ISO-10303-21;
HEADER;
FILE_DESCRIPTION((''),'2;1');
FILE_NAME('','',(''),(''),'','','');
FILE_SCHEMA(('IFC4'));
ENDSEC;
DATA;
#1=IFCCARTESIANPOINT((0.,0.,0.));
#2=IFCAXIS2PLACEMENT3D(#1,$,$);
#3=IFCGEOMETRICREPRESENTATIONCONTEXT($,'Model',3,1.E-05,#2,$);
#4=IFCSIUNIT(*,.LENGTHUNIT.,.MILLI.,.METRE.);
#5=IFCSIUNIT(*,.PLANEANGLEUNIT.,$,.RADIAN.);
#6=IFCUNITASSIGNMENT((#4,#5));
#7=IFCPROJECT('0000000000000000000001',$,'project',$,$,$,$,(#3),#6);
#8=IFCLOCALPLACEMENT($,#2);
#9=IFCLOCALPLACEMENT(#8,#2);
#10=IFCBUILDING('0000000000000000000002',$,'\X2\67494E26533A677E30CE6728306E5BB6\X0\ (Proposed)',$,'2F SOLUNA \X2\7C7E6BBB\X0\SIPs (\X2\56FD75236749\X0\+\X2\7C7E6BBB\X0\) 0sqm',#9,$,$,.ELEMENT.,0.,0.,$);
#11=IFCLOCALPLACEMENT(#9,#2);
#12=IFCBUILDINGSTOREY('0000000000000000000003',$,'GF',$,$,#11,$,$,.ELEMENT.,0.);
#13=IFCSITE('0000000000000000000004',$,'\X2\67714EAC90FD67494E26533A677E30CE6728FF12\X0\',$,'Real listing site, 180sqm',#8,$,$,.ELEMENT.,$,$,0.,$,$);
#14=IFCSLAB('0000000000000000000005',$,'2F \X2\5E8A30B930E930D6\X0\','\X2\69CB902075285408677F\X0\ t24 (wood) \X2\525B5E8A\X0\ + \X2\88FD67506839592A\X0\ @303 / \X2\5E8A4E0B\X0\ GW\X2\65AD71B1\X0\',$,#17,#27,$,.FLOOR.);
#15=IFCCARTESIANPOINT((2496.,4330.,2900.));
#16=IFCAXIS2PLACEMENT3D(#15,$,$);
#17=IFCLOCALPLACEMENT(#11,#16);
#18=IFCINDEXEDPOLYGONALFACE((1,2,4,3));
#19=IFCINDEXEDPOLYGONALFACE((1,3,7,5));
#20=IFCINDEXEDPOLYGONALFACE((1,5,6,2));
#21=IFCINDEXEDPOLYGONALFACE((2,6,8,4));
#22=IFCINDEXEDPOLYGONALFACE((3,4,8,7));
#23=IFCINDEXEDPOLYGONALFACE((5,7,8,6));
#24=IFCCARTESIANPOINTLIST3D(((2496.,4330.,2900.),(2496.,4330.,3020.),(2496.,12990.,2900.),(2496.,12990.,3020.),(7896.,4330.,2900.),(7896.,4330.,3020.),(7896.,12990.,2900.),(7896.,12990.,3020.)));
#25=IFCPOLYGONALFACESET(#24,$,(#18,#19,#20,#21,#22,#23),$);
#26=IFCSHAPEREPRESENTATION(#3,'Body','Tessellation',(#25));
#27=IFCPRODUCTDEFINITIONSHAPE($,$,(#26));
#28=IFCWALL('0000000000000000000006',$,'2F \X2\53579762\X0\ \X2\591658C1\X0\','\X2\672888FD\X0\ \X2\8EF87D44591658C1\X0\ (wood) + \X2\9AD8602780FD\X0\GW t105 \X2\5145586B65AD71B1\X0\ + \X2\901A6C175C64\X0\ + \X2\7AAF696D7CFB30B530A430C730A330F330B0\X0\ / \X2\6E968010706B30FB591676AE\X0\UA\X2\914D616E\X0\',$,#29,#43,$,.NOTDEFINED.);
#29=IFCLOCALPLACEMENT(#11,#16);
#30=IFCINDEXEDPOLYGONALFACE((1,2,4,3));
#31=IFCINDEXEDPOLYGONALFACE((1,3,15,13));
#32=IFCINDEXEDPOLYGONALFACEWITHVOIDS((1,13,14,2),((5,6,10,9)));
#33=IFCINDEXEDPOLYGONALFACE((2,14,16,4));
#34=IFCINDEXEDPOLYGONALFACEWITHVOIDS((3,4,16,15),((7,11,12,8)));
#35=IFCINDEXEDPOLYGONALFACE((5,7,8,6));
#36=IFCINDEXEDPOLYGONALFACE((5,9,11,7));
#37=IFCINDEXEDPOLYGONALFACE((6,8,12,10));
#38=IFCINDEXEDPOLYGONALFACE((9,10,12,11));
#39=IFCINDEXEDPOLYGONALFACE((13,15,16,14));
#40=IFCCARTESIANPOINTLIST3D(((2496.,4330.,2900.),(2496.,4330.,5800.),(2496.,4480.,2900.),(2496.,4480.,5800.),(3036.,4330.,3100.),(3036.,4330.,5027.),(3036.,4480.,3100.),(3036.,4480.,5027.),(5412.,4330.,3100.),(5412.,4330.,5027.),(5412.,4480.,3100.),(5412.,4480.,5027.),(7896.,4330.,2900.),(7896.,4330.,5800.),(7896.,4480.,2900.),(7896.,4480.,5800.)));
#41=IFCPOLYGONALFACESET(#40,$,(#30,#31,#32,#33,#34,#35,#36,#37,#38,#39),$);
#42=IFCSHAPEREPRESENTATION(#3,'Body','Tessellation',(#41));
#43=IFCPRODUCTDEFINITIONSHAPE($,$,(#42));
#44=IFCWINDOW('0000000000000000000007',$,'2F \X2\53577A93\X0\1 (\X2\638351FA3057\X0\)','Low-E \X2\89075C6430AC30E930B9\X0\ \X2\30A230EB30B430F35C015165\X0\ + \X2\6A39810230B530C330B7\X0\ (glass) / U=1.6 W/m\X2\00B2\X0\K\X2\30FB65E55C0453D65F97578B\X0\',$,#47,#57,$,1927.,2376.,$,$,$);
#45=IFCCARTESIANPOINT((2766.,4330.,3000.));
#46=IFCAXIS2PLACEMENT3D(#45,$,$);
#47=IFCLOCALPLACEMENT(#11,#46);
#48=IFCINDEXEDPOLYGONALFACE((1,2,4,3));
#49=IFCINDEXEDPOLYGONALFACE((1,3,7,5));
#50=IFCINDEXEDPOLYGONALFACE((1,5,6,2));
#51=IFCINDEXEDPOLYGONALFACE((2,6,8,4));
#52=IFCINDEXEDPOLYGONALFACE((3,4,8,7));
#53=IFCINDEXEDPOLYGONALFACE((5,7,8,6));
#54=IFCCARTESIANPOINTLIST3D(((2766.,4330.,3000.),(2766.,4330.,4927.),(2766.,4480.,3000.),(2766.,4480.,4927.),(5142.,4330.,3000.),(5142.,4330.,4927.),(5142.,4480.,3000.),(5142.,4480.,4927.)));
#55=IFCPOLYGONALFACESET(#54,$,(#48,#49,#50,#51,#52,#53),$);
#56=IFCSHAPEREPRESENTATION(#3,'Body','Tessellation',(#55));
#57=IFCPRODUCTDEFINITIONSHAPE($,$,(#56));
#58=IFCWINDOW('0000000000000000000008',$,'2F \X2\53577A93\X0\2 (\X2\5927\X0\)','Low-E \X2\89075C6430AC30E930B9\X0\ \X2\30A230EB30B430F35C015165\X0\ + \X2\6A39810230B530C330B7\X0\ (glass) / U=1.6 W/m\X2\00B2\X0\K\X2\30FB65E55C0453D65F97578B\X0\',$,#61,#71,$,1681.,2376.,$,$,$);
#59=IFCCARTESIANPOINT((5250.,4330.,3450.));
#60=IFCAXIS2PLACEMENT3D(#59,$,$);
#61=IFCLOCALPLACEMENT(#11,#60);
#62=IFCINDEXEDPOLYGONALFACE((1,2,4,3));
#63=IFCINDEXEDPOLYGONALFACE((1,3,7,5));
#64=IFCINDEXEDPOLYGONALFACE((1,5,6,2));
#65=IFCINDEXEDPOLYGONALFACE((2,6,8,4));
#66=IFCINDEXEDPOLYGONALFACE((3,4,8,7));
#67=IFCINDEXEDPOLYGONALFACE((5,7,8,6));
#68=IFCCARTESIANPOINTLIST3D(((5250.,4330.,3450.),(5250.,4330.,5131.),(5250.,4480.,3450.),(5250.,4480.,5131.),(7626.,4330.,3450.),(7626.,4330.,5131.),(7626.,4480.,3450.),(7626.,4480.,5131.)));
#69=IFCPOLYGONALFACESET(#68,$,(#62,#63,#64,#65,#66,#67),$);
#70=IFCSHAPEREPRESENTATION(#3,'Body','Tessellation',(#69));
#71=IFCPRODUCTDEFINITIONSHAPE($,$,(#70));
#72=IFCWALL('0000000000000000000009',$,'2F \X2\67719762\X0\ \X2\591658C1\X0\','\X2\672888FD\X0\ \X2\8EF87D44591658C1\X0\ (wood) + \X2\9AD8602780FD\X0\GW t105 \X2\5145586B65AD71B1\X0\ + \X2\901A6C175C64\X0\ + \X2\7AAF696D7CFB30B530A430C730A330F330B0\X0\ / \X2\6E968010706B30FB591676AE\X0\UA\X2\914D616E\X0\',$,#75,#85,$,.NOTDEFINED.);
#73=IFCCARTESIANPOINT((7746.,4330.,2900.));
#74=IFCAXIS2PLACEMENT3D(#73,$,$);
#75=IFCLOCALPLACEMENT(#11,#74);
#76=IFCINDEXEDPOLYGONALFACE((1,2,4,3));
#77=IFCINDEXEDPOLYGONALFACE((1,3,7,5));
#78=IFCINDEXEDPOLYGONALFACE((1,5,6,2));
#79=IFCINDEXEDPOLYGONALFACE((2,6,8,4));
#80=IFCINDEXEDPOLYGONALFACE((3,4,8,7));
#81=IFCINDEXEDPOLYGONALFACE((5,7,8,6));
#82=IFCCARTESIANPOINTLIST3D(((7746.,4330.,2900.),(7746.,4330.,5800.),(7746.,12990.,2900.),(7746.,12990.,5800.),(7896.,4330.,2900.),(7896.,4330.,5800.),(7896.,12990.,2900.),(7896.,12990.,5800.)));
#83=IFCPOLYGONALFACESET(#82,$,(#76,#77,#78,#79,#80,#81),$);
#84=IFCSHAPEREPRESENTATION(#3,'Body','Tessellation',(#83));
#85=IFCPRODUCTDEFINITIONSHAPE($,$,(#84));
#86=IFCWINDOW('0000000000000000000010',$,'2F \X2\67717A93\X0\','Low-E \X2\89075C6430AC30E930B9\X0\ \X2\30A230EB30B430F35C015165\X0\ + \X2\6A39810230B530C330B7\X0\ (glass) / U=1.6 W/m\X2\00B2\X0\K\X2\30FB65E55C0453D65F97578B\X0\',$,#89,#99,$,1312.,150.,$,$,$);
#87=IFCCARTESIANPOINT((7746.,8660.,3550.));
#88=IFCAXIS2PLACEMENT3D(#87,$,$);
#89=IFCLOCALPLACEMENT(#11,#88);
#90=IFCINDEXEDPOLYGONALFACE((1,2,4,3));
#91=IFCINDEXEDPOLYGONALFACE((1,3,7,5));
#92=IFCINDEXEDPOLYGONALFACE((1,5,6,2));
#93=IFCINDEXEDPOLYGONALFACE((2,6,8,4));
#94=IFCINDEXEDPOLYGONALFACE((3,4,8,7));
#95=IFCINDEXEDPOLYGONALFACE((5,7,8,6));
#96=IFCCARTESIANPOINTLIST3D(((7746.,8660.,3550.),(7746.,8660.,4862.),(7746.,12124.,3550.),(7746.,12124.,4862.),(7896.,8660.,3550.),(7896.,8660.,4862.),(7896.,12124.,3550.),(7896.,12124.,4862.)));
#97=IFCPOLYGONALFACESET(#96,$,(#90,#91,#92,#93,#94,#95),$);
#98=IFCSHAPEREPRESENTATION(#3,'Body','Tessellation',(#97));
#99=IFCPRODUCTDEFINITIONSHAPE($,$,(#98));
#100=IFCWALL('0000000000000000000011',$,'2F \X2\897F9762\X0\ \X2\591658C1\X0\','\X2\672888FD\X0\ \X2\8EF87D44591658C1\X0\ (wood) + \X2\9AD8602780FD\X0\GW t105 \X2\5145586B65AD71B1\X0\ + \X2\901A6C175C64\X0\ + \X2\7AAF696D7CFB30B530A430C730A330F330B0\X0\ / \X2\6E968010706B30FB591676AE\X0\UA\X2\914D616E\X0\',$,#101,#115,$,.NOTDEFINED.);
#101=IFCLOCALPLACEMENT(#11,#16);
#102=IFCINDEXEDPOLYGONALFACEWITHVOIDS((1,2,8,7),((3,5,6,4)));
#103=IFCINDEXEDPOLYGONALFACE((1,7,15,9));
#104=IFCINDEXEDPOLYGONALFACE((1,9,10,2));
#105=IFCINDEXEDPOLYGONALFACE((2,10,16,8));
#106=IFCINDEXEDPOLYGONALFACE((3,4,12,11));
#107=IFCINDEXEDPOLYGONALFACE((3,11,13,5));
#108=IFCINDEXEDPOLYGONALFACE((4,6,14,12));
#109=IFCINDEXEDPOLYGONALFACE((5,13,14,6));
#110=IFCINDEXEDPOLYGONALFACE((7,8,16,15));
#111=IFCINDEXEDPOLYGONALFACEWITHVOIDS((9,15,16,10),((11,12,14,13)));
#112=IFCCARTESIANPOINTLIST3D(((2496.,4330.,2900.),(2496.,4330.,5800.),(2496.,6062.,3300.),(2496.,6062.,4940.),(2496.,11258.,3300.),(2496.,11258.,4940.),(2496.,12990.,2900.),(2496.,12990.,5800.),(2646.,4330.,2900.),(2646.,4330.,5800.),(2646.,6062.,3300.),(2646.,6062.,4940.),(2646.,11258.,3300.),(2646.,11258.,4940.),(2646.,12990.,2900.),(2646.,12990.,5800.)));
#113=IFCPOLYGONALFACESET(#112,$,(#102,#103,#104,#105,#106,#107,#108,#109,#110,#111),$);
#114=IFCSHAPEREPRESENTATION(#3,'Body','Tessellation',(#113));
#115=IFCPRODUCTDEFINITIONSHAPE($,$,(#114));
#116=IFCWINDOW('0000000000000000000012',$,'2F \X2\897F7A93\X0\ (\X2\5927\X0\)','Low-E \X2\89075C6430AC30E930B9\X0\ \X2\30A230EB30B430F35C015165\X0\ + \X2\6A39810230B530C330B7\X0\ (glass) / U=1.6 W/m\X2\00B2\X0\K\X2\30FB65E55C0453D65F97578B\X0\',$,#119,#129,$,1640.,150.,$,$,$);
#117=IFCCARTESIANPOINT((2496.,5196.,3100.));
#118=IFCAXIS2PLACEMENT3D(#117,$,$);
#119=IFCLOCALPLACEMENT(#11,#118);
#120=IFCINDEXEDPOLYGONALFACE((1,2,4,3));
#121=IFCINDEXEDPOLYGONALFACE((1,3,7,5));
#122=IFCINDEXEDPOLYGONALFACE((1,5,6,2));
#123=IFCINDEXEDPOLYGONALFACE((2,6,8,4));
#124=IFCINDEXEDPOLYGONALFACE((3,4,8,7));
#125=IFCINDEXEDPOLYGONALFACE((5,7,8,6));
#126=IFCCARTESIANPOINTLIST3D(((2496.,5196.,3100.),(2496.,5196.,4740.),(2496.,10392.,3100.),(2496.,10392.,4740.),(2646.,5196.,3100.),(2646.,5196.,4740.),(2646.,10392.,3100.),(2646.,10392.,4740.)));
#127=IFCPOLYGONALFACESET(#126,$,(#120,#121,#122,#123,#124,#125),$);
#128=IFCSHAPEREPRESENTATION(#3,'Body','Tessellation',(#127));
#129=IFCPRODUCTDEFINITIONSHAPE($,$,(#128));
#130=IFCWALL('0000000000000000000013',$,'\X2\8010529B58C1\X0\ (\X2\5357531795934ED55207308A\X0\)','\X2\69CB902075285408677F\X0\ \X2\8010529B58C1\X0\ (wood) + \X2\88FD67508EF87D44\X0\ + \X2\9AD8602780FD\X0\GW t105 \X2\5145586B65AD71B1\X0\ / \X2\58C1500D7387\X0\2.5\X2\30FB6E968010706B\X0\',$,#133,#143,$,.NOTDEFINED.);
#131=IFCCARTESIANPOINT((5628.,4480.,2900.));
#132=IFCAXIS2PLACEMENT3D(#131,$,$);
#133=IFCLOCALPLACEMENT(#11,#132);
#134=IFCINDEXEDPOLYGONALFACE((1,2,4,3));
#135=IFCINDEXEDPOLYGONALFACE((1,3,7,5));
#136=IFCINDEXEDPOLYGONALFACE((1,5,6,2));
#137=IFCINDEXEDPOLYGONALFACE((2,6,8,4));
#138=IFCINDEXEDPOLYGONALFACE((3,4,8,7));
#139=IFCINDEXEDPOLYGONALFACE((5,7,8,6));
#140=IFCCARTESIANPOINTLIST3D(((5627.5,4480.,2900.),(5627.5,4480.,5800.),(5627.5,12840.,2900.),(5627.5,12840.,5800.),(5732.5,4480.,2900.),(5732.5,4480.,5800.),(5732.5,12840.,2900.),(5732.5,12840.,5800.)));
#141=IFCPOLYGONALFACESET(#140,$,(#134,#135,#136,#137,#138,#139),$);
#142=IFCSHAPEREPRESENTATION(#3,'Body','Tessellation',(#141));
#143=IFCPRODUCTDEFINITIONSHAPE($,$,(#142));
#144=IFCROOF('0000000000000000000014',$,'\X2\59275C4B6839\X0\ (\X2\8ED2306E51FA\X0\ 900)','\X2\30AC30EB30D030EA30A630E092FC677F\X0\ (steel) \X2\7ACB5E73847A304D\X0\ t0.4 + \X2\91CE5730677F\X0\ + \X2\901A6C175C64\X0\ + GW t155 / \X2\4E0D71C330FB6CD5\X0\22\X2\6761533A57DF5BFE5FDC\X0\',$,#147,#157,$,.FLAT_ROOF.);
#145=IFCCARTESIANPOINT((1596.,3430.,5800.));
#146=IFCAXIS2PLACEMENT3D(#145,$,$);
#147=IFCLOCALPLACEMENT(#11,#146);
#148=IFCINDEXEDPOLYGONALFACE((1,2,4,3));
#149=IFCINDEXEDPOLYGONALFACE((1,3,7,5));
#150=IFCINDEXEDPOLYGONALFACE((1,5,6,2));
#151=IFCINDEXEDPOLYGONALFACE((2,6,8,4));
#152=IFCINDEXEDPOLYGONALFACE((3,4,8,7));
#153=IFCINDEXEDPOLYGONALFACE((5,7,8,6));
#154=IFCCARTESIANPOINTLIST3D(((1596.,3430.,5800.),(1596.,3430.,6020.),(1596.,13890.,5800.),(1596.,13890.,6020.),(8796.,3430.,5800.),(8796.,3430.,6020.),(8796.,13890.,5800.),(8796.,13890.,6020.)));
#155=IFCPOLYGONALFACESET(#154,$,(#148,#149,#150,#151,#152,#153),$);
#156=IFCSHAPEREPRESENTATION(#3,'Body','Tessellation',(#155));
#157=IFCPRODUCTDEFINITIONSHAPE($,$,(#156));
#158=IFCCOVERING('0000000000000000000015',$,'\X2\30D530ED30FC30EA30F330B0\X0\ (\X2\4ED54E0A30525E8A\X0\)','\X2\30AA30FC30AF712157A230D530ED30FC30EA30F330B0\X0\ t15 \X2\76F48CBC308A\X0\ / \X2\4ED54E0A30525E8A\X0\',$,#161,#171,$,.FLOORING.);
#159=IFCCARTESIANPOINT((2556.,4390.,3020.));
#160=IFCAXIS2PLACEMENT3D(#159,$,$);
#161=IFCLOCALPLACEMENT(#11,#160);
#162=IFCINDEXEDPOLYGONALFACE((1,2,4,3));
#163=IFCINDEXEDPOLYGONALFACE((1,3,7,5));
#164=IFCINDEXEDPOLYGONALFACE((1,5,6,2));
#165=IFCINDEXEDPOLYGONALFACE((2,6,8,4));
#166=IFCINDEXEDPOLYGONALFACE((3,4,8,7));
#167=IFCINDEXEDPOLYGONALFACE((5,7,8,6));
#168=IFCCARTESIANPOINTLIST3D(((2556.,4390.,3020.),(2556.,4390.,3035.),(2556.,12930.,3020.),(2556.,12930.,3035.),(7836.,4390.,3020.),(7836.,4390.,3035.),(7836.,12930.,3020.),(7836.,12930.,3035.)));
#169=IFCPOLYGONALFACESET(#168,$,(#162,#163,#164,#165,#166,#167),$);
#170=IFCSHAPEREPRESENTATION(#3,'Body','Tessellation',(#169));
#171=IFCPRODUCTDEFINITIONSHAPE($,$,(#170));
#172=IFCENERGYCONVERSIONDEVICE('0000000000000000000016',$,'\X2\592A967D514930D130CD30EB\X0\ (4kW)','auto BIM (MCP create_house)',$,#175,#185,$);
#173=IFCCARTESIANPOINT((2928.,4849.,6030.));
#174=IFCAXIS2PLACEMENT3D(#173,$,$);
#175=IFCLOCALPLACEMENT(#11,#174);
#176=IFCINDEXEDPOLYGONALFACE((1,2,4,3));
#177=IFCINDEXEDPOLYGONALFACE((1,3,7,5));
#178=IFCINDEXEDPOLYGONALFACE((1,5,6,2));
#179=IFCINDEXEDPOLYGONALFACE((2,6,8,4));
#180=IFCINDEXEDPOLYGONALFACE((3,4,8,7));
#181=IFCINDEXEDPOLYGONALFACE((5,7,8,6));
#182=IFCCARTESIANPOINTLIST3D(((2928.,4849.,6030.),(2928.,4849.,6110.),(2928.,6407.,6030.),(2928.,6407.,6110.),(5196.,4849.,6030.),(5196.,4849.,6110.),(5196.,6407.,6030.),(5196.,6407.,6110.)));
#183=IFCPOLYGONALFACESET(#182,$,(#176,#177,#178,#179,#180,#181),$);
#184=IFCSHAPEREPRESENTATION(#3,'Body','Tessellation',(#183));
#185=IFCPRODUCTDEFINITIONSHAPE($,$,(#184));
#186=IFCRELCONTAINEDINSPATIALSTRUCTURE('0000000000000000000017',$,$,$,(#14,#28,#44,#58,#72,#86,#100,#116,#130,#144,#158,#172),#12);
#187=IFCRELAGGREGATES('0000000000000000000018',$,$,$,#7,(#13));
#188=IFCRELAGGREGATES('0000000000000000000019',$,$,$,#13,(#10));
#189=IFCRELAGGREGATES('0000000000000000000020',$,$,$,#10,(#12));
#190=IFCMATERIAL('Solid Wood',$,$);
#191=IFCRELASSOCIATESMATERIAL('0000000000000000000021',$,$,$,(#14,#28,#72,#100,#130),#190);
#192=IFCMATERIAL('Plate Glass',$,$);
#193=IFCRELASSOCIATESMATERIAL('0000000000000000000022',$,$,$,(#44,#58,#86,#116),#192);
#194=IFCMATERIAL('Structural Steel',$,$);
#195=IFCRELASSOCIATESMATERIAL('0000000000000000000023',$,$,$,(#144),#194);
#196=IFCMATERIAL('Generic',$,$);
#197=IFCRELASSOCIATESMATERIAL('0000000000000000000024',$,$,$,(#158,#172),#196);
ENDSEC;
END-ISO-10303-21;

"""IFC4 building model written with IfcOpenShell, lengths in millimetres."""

from ifc_helpers import new_model, si_unit, frame, frame_2d, origin, place, context, project, spatial, rectangle, extrude, material, element, fill, save


model = new_model("IFC4")

# Units and contexts
model_context = context("Model", 3, precision=1e-05, world=origin())
ifc_project = project(units=[si_unit("LENGTHUNIT", "METRE", prefix="MILLI"), si_unit("PLANEANGLEUNIT", "RADIAN")], contexts=[model_context])

# Site, building, storey
site_placement = place(None, origin())
site = spatial("IfcSite", under=ifc_project, at=site_placement, Name="東京都杉並区松ノ木２", ObjectType="Real listing site, 180sqm", CompositionType="ELEMENT", RefElevation=0.0)
building_placement = place(site_placement, origin())
building = spatial("IfcBuilding", under=site, at=building_placement, Name="杉並区松ノ木の家 (Proposed)", ObjectType="2F SOLUNA 籾殻SIPs (国産杉+籾殻) 0sqm", CompositionType="ELEMENT", ElevationOfRefHeight=0.0, ElevationOfTerrain=0.0)
storey_placement = place(building_placement, origin())
storey = spatial("IfcBuildingStorey", under=building, at=storey_placement, Name="GF", CompositionType="ELEMENT", Elevation=0.0)

# Slab
ifc_material_1 = material(Name="Solid Wood")
slab_placement = place(storey_placement, frame((2496.0, 4330.0, 2900.0)))
element("IfcSlab", 1, at=slab_placement, inside=storey, material=ifc_material_1, Name="2F 床スラブ", Description="構造用合板 t24 (wood) 剛床 + 製材根太 @303 / 床下 GW断熱", PredefinedType="FLOOR", context=model_context, shape_type="SweptSolid", body=[
    extrude(rectangle(XDim=5400.0, YDim=8660.0, at=frame_2d((2700.0, 4330.0))), frame((2496.0, 4330.0, 2900.0)), (0.0, 0.0, 1.0), 120.0),
])

# Wall, openings, windows
wall_1_placement = place(storey_placement, frame((2496.0, 4330.0, 2900.0)))
wall_1 = element("IfcWall", 2, at=wall_1_placement, inside=storey, material=ifc_material_1, Name="2F 南面 外壁", Description="木製 軸組外壁 (wood) + 高性能GW t105 充填断熱 + 通気層 + 窯業系サイディング / 準耐火・外皮UA配慮", PredefinedType="NOTDEFINED", context=model_context, shape_type="SweptSolid", body=[
    extrude(rectangle(XDim=5400.0, YDim=150.0, at=frame_2d((2700.0, 75.0))), frame((2496.0, 4330.0, 2900.0)), (0.0, 0.0, 1.0), 2900.0),
])
opening_1_placement = place(storey_placement, frame((2766.0, 4330.0, 3000.0)))
opening_1 = element("IfcOpeningElement", 3, at=opening_1_placement, cuts=wall_1, PredefinedType="NOTDEFINED", context=model_context, shape_type="SweptSolid", body=[
    extrude(rectangle(XDim=2376.0, YDim=150.0, at=frame_2d((1188.0, 75.0))), frame((2766.0, 4330.0, 3000.0)), (0.0, 0.0, 1.0), 1927.0),
])
opening_2_placement = place(storey_placement, frame((5250.0, 4330.0, 3450.0)))
opening_2 = element("IfcOpeningElement", 4, at=opening_2_placement, cuts=wall_1, PredefinedType="NOTDEFINED", context=model_context, shape_type="SweptSolid", body=[
    extrude(rectangle(XDim=2376.0, YDim=150.0, at=frame_2d((1188.0, 75.0))), frame((5250.0, 4330.0, 3450.0)), (0.0, 0.0, 1.0), 1681.0),
])
ifc_material_2 = material(Name="Plate Glass")
window_1_placement = place(storey_placement, frame((2766.0, 4330.0, 3000.0)))
window_1 = element("IfcWindow", 5, at=window_1_placement, inside=storey, material=ifc_material_2, Name="2F 南窓1 (掃出し)", Description="Low-E 複層ガラス アルゴン封入 + 樹脂サッシ (glass) / U=1.6 W/m²K・日射取得型", OverallHeight=1927.0, OverallWidth=2376.0, context=model_context, shape_type="SweptSolid", body=[
    extrude(rectangle(XDim=2376.0, YDim=150.0, at=frame_2d((1188.0, 75.0))), frame((2766.0, 4330.0, 3000.0)), (0.0, 0.0, 1.0), 1927.0),
])
fill(opening_1, window_1)
window_2_placement = place(storey_placement, frame((5250.0, 4330.0, 3450.0)))
window_2 = element("IfcWindow", 6, at=window_2_placement, inside=storey, material=ifc_material_2, Name="2F 南窓2 (大)", Description="Low-E 複層ガラス アルゴン封入 + 樹脂サッシ (glass) / U=1.6 W/m²K・日射取得型", OverallHeight=1681.0, OverallWidth=2376.0, context=model_context, shape_type="SweptSolid", body=[
    extrude(rectangle(XDim=2376.0, YDim=150.0, at=frame_2d((1188.0, 75.0))), frame((5250.0, 4330.0, 3450.0)), (0.0, 0.0, 1.0), 1681.0),
])
fill(opening_2, window_2)

# Walls, openings, windows
wall_2_placement = place(storey_placement, frame((7746.0, 4330.0, 2900.0)))
wall_2 = element("IfcWall", 7, at=wall_2_placement, inside=storey, material=ifc_material_1, Name="2F 東面 外壁", Description="木製 軸組外壁 (wood) + 高性能GW t105 充填断熱 + 通気層 + 窯業系サイディング / 準耐火・外皮UA配慮", PredefinedType="NOTDEFINED", context=model_context, shape_type="SweptSolid", body=[
    extrude(rectangle(XDim=150.0, YDim=8660.0, at=frame_2d((75.0, 4330.0))), frame((7746.0, 4330.0, 2900.0)), (0.0, 0.0, 1.0), 2900.0),
])
opening_3_placement = place(storey_placement, frame((7746.0, 8660.0, 3550.0)))
opening_3 = element("IfcOpeningElement", 8, at=opening_3_placement, cuts=wall_2, PredefinedType="NOTDEFINED", context=model_context, shape_type="SweptSolid", body=[
    extrude(rectangle(XDim=150.0, YDim=3464.0, at=frame_2d((75.0, 1732.0))), frame((7746.0, 8660.0, 3550.0)), (0.0, 0.0, 1.0), 1312.0),
])
window_3_placement = place(storey_placement, frame((7746.0, 8660.0, 3550.0)))
window_3 = element("IfcWindow", 9, at=window_3_placement, inside=storey, material=ifc_material_2, Name="2F 東窓", Description="Low-E 複層ガラス アルゴン封入 + 樹脂サッシ (glass) / U=1.6 W/m²K・日射取得型", OverallHeight=1312.0, OverallWidth=150.0, context=model_context, shape_type="SweptSolid", body=[
    extrude(rectangle(XDim=150.0, YDim=3464.0, at=frame_2d((75.0, 1732.0))), frame((7746.0, 8660.0, 3550.0)), (0.0, 0.0, 1.0), 1312.0),
])
fill(opening_3, window_3)
wall_3_placement = place(storey_placement, frame((2496.0, 4330.0, 2900.0)))
wall_3 = element("IfcWall", 10, at=wall_3_placement, inside=storey, material=ifc_material_1, Name="2F 西面 外壁", Description="木製 軸組外壁 (wood) + 高性能GW t105 充填断熱 + 通気層 + 窯業系サイディング / 準耐火・外皮UA配慮", PredefinedType="NOTDEFINED", context=model_context, shape_type="SweptSolid", body=[
    extrude(rectangle(XDim=150.0, YDim=8660.0, at=frame_2d((75.0, 4330.0))), frame((2496.0, 4330.0, 2900.0)), (0.0, 0.0, 1.0), 2900.0),
])
opening_4_placement = place(storey_placement, frame((2496.0, 5196.0, 3100.0)))
opening_4 = element("IfcOpeningElement", 11, at=opening_4_placement, cuts=wall_3, PredefinedType="NOTDEFINED", context=model_context, shape_type="SweptSolid", body=[
    extrude(rectangle(XDim=150.0, YDim=5196.0, at=frame_2d((75.0, 2598.0))), frame((2496.0, 5196.0, 3100.0)), (0.0, 0.0, 1.0), 1640.0),
])
window_4_placement = place(storey_placement, frame((2496.0, 5196.0, 3100.0)))
window_4 = element("IfcWindow", 12, at=window_4_placement, inside=storey, material=ifc_material_2, Name="2F 西窓 (大)", Description="Low-E 複層ガラス アルゴン封入 + 樹脂サッシ (glass) / U=1.6 W/m²K・日射取得型", OverallHeight=1640.0, OverallWidth=150.0, context=model_context, shape_type="SweptSolid", body=[
    extrude(rectangle(XDim=150.0, YDim=5196.0, at=frame_2d((75.0, 2598.0))), frame((2496.0, 5196.0, 3100.0)), (0.0, 0.0, 1.0), 1640.0),
])
fill(opening_4, window_4)

# Wall
wall_4_placement = place(storey_placement, frame((5628.0, 4480.0, 2900.0)))
element("IfcWall", 13, at=wall_4_placement, inside=storey, material=ifc_material_1, Name="耐力壁 (南北間仕切り)", Description="構造用合板 耐力壁 (wood) + 製材軸組 + 高性能GW t105 充填断熱 / 壁倍率2.5・準耐火", PredefinedType="NOTDEFINED", context=model_context, shape_type="SweptSolid", body=[
    extrude(rectangle(XDim=105.0, YDim=8360.0, at=frame_2d((52.0, 4180.0))), frame((5628.0, 4480.0, 2900.0)), (0.0, 0.0, 1.0), 2900.0),
])

# Roof
ifc_material_3 = material(Name="Structural Steel")
roof_placement = place(storey_placement, frame((1596.0, 3430.0, 5800.0)))
element("IfcRoof", 14, at=roof_placement, inside=storey, material=ifc_material_3, Name="大屋根 (軒の出 900)", Description="ガルバリウム鋼板 (steel) 立平葺き t0.4 + 野地板 + 通気層 + GW t155 / 不燃・法22条区域対応", PredefinedType="FLAT_ROOF", context=model_context, shape_type="SweptSolid", body=[
    extrude(rectangle(XDim=7200.0, YDim=10460.0, at=frame_2d((3600.0, 5230.0))), frame((1596.0, 3430.0, 5800.0)), (0.0, 0.0, 1.0), 220.0),
])

# Covering
ifc_material_4 = material(Name="Generic")
covering_placement = place(storey_placement, frame((2556.0, 4390.0, 3020.0)))
element("IfcCovering", 15, at=covering_placement, inside=storey, material=ifc_material_4, Name="フローリング (仕上げ床)", Description="オーク無垢フローリング t15 直貼り / 仕上げ床", PredefinedType="FLOORING", context=model_context, shape_type="SweptSolid", body=[
    extrude(rectangle(XDim=5280.0, YDim=8540.0, at=frame_2d((2640.0, 4270.0))), frame((2556.0, 4390.0, 3020.0)), (0.0, 0.0, 1.0), 15.0),
])

# Energy conversion device
energy_conversion_device_placement = place(storey_placement, frame((2928.0, 4849.0, 6030.0)))
element("IfcEnergyConversionDevice", 16, at=energy_conversion_device_placement, inside=storey, material=ifc_material_4, Name="太陽光パネル (4kW)", Description="auto BIM (MCP create_house)", context=model_context, shape_type="SweptSolid", body=[
    extrude(rectangle(XDim=2268.0, YDim=1558.0, at=frame_2d((1134.0, 779.0))), frame((2928.0, 4849.0, 6030.0)), (0.0, 0.0, 1.0), 80.0),
])

save(model, "model.ifc")
